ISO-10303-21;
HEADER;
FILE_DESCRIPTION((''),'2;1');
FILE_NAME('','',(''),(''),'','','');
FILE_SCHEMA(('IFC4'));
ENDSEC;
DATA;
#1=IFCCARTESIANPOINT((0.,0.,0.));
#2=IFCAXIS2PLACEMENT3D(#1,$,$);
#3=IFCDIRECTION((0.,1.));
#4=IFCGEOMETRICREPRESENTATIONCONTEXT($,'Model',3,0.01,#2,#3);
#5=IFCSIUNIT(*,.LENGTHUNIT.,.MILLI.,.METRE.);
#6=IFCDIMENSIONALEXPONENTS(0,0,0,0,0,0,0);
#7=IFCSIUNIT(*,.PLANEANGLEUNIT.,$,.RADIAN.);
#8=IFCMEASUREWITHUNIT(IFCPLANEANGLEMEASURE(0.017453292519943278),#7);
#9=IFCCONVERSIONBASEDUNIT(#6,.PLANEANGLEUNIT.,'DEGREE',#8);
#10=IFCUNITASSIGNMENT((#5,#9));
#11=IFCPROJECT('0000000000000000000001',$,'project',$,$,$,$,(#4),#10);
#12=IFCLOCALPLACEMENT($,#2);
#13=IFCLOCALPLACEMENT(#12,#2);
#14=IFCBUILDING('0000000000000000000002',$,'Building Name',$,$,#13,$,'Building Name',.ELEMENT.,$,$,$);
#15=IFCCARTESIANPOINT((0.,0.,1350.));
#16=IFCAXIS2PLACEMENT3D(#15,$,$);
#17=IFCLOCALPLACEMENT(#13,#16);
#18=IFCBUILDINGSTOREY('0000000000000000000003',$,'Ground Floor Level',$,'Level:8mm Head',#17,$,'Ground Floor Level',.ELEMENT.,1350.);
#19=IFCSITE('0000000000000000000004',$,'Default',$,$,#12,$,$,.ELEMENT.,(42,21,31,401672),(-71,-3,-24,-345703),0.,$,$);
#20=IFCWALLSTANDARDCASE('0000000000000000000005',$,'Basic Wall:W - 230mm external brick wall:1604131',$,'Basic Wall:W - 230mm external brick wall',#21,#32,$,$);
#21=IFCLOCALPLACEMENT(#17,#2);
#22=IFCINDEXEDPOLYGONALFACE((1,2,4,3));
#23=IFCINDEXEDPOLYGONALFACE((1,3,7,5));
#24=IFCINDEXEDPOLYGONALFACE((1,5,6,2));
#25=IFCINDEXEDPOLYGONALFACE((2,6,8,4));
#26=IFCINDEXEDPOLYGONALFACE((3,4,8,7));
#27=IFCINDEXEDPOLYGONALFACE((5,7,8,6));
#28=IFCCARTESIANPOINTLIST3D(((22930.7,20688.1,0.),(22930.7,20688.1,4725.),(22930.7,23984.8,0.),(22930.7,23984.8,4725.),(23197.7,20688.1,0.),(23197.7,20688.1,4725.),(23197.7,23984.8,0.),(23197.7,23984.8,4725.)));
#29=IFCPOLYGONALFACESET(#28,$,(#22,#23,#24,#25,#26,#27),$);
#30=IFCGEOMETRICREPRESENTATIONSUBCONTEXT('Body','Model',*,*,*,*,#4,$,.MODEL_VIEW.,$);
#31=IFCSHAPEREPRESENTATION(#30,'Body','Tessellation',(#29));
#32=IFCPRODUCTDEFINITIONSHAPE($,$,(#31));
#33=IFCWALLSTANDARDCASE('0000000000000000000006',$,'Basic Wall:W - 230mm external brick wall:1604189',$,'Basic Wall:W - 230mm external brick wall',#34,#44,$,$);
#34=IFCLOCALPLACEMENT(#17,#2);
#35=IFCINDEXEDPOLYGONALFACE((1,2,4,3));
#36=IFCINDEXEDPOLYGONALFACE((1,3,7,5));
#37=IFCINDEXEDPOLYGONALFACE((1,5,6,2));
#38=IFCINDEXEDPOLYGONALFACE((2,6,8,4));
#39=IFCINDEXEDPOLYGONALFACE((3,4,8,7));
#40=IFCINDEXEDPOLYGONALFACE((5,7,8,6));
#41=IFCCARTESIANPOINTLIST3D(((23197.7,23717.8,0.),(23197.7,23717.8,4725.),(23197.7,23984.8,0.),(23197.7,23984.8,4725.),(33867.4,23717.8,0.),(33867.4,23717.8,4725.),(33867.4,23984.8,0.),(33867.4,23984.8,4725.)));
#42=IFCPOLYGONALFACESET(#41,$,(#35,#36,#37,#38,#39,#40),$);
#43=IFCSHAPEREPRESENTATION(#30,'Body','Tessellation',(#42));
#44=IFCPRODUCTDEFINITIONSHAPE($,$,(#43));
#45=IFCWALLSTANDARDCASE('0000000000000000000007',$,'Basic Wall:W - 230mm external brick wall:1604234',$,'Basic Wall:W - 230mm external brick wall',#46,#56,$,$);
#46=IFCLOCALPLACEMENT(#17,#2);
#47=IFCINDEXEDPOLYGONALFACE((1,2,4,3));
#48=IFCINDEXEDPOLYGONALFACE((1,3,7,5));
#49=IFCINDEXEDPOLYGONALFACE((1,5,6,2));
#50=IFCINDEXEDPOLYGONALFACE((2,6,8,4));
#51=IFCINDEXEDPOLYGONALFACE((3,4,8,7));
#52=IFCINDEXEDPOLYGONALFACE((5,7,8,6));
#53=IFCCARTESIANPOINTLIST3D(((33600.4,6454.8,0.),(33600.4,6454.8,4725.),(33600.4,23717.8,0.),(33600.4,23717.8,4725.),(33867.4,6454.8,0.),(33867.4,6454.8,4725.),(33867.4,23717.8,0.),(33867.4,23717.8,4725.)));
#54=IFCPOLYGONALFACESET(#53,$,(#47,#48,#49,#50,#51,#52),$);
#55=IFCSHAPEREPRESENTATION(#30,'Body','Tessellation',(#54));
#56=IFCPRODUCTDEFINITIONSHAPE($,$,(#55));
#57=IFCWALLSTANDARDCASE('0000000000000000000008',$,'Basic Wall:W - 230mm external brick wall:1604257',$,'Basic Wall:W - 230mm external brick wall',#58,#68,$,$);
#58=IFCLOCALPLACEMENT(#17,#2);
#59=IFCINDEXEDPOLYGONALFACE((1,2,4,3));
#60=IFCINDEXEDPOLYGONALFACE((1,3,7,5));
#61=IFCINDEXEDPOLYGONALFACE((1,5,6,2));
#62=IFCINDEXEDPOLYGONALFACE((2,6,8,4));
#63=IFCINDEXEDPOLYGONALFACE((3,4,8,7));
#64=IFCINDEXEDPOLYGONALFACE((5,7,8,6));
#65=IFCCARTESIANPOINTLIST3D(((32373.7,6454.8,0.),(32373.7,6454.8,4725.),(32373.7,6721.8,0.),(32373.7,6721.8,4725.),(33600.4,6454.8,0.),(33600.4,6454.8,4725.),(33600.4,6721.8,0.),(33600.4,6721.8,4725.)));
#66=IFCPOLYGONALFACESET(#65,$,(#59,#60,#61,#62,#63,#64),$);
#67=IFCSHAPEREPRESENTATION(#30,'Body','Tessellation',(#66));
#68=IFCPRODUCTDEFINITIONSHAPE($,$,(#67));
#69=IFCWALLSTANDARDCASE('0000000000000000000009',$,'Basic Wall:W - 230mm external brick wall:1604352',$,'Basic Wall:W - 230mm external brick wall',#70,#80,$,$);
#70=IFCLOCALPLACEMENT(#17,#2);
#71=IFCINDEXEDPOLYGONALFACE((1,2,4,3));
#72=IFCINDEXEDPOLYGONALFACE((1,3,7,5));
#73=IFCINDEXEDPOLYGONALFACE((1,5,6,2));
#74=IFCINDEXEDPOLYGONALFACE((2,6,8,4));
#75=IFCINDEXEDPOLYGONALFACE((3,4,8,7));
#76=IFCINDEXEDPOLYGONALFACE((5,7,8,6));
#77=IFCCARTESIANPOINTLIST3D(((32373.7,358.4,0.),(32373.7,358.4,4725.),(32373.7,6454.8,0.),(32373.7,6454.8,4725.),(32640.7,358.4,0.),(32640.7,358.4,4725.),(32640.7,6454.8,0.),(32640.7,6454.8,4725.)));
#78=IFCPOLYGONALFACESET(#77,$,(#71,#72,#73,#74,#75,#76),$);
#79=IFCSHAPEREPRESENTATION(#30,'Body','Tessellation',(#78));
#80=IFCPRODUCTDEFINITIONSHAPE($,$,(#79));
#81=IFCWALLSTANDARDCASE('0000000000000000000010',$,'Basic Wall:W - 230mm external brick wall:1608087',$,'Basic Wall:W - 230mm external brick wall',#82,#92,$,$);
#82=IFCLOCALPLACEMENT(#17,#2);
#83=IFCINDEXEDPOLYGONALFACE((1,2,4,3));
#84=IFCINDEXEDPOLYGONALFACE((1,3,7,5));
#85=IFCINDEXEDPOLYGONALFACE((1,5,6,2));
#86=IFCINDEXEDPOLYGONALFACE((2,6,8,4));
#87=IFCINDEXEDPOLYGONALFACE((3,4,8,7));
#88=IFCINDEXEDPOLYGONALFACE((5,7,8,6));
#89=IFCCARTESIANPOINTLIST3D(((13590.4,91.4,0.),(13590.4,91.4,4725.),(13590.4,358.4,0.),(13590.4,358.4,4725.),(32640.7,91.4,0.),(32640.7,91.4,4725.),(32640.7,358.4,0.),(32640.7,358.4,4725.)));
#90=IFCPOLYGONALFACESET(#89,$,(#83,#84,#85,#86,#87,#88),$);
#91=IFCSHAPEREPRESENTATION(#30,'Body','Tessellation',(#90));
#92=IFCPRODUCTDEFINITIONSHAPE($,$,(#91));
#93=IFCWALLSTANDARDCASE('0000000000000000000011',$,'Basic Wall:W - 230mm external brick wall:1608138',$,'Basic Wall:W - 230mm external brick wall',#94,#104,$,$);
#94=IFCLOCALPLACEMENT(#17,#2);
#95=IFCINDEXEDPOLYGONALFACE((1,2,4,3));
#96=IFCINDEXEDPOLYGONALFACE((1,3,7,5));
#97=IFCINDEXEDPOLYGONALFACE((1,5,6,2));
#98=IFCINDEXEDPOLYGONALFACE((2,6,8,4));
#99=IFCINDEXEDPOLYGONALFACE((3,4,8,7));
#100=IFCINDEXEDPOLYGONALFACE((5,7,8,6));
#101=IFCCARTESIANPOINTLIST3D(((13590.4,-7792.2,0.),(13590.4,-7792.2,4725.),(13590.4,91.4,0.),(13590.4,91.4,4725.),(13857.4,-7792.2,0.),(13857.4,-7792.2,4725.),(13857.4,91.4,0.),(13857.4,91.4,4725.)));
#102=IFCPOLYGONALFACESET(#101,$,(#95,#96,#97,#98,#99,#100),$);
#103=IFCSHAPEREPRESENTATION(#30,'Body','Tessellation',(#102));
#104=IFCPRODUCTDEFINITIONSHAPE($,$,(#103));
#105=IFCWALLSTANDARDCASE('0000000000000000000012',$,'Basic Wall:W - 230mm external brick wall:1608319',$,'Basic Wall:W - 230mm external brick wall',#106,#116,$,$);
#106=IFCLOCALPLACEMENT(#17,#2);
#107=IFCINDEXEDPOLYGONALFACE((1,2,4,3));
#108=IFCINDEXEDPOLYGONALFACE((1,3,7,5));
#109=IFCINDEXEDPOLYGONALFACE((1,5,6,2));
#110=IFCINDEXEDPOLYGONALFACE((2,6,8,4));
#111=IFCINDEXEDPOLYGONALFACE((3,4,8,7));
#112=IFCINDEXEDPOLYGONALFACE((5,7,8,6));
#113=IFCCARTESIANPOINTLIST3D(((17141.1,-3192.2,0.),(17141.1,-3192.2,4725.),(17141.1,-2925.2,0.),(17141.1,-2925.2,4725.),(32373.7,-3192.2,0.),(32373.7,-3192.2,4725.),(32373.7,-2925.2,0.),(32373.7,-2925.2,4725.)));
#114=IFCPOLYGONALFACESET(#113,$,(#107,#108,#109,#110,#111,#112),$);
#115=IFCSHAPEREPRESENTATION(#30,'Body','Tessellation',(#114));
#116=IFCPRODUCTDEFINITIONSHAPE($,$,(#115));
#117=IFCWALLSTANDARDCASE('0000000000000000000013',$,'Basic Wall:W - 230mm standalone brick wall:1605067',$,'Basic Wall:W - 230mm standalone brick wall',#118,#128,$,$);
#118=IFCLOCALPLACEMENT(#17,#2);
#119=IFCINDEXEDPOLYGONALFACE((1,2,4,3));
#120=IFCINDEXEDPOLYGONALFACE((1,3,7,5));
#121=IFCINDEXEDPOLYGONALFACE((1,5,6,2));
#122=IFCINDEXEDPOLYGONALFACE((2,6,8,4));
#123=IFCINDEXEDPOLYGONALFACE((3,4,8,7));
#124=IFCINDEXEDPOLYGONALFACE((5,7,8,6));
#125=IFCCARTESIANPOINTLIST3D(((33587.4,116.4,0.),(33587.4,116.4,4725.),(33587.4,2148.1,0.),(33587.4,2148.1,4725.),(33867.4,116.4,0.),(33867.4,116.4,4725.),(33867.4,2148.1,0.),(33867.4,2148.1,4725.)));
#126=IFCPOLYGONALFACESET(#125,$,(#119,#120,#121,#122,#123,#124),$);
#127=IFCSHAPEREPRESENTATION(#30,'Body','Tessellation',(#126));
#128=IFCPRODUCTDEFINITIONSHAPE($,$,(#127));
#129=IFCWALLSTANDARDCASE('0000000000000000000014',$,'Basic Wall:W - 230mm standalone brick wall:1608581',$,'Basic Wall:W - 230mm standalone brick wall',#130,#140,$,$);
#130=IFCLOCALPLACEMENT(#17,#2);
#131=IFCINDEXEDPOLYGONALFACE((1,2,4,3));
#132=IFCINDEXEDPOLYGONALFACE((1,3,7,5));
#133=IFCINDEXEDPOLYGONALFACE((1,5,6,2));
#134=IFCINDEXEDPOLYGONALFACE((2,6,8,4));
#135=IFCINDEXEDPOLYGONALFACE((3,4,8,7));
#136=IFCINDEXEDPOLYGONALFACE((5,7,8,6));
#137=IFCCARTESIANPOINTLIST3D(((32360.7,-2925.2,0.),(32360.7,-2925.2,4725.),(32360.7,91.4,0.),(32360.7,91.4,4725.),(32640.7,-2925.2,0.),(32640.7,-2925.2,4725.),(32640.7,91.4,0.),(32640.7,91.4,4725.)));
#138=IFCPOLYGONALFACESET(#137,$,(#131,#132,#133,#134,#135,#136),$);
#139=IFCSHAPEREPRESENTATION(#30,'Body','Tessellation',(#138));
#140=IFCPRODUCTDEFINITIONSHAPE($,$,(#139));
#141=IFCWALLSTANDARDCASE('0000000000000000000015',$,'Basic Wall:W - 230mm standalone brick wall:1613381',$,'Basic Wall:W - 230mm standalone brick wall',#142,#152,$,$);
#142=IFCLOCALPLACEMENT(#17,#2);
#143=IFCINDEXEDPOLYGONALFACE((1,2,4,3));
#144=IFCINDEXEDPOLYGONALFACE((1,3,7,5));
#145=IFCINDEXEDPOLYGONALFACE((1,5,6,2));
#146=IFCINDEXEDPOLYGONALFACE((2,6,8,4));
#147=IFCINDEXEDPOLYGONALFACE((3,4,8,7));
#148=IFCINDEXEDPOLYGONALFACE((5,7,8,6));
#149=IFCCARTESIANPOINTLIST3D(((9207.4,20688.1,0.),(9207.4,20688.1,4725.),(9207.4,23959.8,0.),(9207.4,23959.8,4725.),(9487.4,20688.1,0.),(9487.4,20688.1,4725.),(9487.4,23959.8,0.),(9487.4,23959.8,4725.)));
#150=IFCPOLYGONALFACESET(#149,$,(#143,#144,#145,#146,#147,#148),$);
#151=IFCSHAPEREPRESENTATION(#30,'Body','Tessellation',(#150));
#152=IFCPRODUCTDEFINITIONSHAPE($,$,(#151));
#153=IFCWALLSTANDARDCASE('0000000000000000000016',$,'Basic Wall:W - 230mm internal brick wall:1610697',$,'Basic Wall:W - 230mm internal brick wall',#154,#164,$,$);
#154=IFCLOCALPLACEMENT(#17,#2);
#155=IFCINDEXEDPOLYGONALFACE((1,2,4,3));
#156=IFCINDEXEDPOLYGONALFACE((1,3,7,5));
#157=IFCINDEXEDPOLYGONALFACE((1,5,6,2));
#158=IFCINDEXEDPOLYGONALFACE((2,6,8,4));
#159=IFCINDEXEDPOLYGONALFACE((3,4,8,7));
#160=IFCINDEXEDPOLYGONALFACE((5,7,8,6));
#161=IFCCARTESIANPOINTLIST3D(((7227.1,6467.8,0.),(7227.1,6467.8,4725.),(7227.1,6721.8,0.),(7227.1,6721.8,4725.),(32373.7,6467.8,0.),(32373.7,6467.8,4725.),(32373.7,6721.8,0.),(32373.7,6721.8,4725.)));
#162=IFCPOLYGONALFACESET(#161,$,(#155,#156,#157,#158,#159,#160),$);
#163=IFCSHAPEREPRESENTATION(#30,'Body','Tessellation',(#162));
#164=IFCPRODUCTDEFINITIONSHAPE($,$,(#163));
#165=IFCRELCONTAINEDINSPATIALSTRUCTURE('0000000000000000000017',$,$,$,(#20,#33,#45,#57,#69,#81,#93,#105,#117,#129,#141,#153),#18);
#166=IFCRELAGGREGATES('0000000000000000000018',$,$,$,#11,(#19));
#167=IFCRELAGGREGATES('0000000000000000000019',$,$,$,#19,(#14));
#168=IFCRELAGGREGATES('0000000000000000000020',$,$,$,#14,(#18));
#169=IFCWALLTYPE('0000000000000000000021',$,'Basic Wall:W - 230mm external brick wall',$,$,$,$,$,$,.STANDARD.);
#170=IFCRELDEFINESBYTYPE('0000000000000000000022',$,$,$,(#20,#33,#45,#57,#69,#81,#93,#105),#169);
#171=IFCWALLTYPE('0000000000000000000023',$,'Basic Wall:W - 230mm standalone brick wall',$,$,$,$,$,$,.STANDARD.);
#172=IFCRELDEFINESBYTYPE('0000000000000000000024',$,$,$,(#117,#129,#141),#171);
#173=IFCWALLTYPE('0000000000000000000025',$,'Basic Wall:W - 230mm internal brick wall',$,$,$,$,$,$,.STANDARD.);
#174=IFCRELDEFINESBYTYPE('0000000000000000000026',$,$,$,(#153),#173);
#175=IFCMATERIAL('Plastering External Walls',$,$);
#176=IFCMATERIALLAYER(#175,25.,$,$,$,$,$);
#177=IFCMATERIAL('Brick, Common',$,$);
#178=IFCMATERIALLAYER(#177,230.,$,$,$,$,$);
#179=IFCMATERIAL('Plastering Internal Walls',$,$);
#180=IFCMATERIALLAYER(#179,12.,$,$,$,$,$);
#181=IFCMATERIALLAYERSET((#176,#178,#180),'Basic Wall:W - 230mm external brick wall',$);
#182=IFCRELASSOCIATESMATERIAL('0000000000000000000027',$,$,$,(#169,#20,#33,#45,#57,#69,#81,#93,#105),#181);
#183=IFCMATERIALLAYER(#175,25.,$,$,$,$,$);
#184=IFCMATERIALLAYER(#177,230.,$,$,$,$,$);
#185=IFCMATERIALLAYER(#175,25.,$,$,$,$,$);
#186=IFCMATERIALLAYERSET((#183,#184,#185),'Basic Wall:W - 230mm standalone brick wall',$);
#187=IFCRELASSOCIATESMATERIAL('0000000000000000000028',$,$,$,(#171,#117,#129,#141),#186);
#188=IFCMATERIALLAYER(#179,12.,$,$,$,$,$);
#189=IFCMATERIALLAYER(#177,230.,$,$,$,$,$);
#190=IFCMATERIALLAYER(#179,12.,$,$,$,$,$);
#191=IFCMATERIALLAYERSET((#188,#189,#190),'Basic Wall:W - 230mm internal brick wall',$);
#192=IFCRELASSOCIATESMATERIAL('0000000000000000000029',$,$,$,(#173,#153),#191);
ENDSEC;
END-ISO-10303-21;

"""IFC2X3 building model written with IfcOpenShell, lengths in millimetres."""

from ifc_helpers import new_model, entity, si_unit, converted_unit, direction, frame, frame_2d, origin, place, context, subcontext, project, spatial, rectangle, extrude, material, layer, layer_set, layer_usage, type_object, element, save


model = new_model("IFC2X3")

# Units and contexts
model_context = context("Model", 3, precision=0.01, world=origin(), true_north=direction((0.0, 1.0)))
body_context = subcontext(model_context, "Body", "Model", "MODEL_VIEW")
ifc_project = project(units=[si_unit("LENGTHUNIT", "METRE", prefix="MILLI"), converted_unit("PLANEANGLEUNIT", "DEGREE", entity("IfcPlaneAngleMeasure", 0.017453292519943278), si_unit("PLANEANGLEUNIT", "RADIAN"), dimensions=[0, 0, 0, 0, 0, 0, 0])], contexts=[model_context])

# Site, building, storey
site_placement = place(None, origin())
site = spatial("IfcSite", under=ifc_project, at=site_placement, Name="Default", CompositionType="ELEMENT", RefLatitude=(42, 21, 31, 401672), RefLongitude=(-71, -3, -24, -345703), RefElevation=0.0)
building_placement = place(site_placement, origin())
building = spatial("IfcBuilding", under=site, at=building_placement, Name="Building Name", LongName="Building Name", CompositionType="ELEMENT")
storey_placement = place(building_placement, frame((0.0, 0.0, 1350.0)))
storey = spatial("IfcBuildingStorey", under=building, at=storey_placement, Name="Ground Floor Level", ObjectType="Level:8mm Head", LongName="Ground Floor Level", CompositionType="ELEMENT", Elevation=1350.0)

# Walls
ifc_material_1 = material(Name="Plastering External Walls")
ifc_layer_1 = layer(ifc_material_1, 25.0)
ifc_material_2 = material(Name="Brick, Common")
ifc_layer_2 = layer(ifc_material_2, 230.0)
ifc_material_3 = material(Name="Plastering Internal Walls")
ifc_layer_3 = layer(ifc_material_3, 12.0)
ifc_layer_set_1 = layer_set([ifc_layer_1, ifc_layer_2, ifc_layer_3], Name="Basic Wall:W - 230mm external brick wall")
ifc_layer_usage_1 = layer_usage(ifc_layer_set_1, "AXIS2", "NEGATIVE", 133.5)
wall_type_1 = type_object("IfcWallType", Name="Basic Wall:W - 230mm external brick wall", PredefinedType="STANDARD", material=ifc_layer_set_1)
wall_1_placement = place(storey_placement, frame((23064.2, 20688.1, 0.0), z_axis=(0.0, 0.0, 1.0), x_axis=(0.0, 1.0, 0.0)))
element("IfcWallStandardCase", 1, at=wall_1_placement, inside=storey, type_object=wall_type_1, material=ifc_layer_usage_1, Name="Basic Wall:W - 230mm external brick wall:1604131", ObjectType="Basic Wall:W - 230mm external brick wall", context=body_context, shape_type="SweptSolid", body=[
    extrude(rectangle(XDim=3296.7, YDim=267.0, at=frame_2d((1648.3, 0.0), x_axis=(-1.0, 0.0))), origin(), (0.0, 0.0, 1.0), 4725.0),
])
ifc_layer_usage_2 = layer_usage(ifc_layer_set_1, "AXIS2", "NEGATIVE", 133.5)
wall_2_placement = place(storey_placement, frame((23197.7, 23851.3, 0.0)))
element("IfcWallStandardCase", 2, at=wall_2_placement, inside=storey, type_object=wall_type_1, material=ifc_layer_usage_2, Name="Basic Wall:W - 230mm external brick wall:1604189", ObjectType="Basic Wall:W - 230mm external brick wall", context=body_context, shape_type="SweptSolid", body=[
    extrude(rectangle(XDim=10669.7, YDim=267.0, at=frame_2d((5334.8, 0.0), x_axis=(-1.0, 0.0))), origin(), (0.0, 0.0, 1.0), 4725.0),
])
ifc_layer_usage_3 = layer_usage(ifc_layer_set_1, "AXIS2", "NEGATIVE", 133.5)
wall_3_placement = place(storey_placement, frame((33733.9, 23717.8, 0.0), z_axis=(0.0, 0.0, 1.0), x_axis=(0.0, -1.0, 0.0)))
element("IfcWallStandardCase", 3, at=wall_3_placement, inside=storey, type_object=wall_type_1, material=ifc_layer_usage_3, Name="Basic Wall:W - 230mm external brick wall:1604234", ObjectType="Basic Wall:W - 230mm external brick wall", context=body_context, shape_type="SweptSolid", body=[
    extrude(rectangle(XDim=17263.0, YDim=267.0, at=frame_2d((8631.5, 0.0), x_axis=(-1.0, 0.0))), origin(), (0.0, 0.0, 1.0), 4725.0),
])
ifc_layer_usage_4 = layer_usage(ifc_layer_set_1, "AXIS2", "NEGATIVE", 133.5)
wall_4_placement = place(storey_placement, frame((33600.4, 6588.3, 0.0), z_axis=(0.0, 0.0, 1.0), x_axis=(-1.0, 0.0, 0.0)))
element("IfcWallStandardCase", 4, at=wall_4_placement, inside=storey, type_object=wall_type_1, material=ifc_layer_usage_4, Name="Basic Wall:W - 230mm external brick wall:1604257", ObjectType="Basic Wall:W - 230mm external brick wall", context=body_context, shape_type="SweptSolid", body=[
    extrude(rectangle(XDim=1226.7, YDim=267.0, at=frame_2d((613.3, 0.0), x_axis=(-1.0, 0.0))), origin(), (0.0, 0.0, 1.0), 4725.0),
])
ifc_layer_usage_5 = layer_usage(ifc_layer_set_1, "AXIS2", "NEGATIVE", 133.5)
wall_5_placement = place(storey_placement, frame((32507.2, 6454.8, 0.0), z_axis=(0.0, 0.0, 1.0), x_axis=(0.0, -1.0, 0.0)))
element("IfcWallStandardCase", 5, at=wall_5_placement, inside=storey, type_object=wall_type_1, material=ifc_layer_usage_5, Name="Basic Wall:W - 230mm external brick wall:1604352", ObjectType="Basic Wall:W - 230mm external brick wall", context=body_context, shape_type="SweptSolid", body=[
    extrude(rectangle(XDim=6096.3, YDim=267.0, at=frame_2d((3048.2, 0.0), x_axis=(-1.0, 0.0))), origin(), (0.0, 0.0, 1.0), 4725.0),
])
ifc_layer_usage_6 = layer_usage(ifc_layer_set_1, "AXIS2", "NEGATIVE", 133.5)
wall_6_placement = place(storey_placement, frame((32640.7, 224.9, 0.0), z_axis=(0.0, 0.0, 1.0), x_axis=(-1.0, 0.0, 0.0)))
element("IfcWallStandardCase", 6, at=wall_6_placement, inside=storey, type_object=wall_type_1, material=ifc_layer_usage_6, Name="Basic Wall:W - 230mm external brick wall:1608087", ObjectType="Basic Wall:W - 230mm external brick wall", context=body_context, shape_type="SweptSolid", body=[
    extrude(rectangle(XDim=19050.3, YDim=267.0, at=frame_2d((9525.2, 0.0), x_axis=(-1.0, 0.0))), origin(), (0.0, 0.0, 1.0), 4725.0),
])
ifc_layer_usage_7 = layer_usage(ifc_layer_set_1, "AXIS2", "NEGATIVE", 133.5)
wall_7_placement = place(storey_placement, frame((13723.9, 91.4, 0.0), z_axis=(0.0, 0.0, 1.0), x_axis=(0.0, -1.0, 0.0)))
element("IfcWallStandardCase", 7, at=wall_7_placement, inside=storey, type_object=wall_type_1, material=ifc_layer_usage_7, Name="Basic Wall:W - 230mm external brick wall:1608138", ObjectType="Basic Wall:W - 230mm external brick wall", context=body_context, shape_type="SweptSolid", body=[
    extrude(rectangle(XDim=7883.7, YDim=267.0, at=frame_2d((3941.8, 0.0), x_axis=(-1.0, 0.0))), origin(), (0.0, 0.0, 1.0), 4725.0),
])
ifc_layer_usage_8 = layer_usage(ifc_layer_set_1, "AXIS2", "NEGATIVE", 133.5)
wall_8_placement = place(storey_placement, frame((17141.1, -3058.7, 0.0)))
element("IfcWallStandardCase", 8, at=wall_8_placement, inside=storey, type_object=wall_type_1, material=ifc_layer_usage_8, Name="Basic Wall:W - 230mm external brick wall:1608319", ObjectType="Basic Wall:W - 230mm external brick wall", context=body_context, shape_type="SweptSolid", body=[
    extrude(rectangle(XDim=15232.7, YDim=267.0, at=frame_2d((7616.3, 0.0), x_axis=(-1.0, 0.0))), origin(), (0.0, 0.0, 1.0), 4725.0),
])
ifc_layer_4 = layer(ifc_material_1, 25.0)
ifc_layer_5 = layer(ifc_material_2, 230.0)
ifc_layer_6 = layer(ifc_material_1, 25.0)
ifc_layer_set_2 = layer_set([ifc_layer_4, ifc_layer_5, ifc_layer_6], Name="Basic Wall:W - 230mm standalone brick wall")
ifc_layer_usage_9 = layer_usage(ifc_layer_set_2, "AXIS2", "NEGATIVE", 140.0)
wall_type_2 = type_object("IfcWallType", Name="Basic Wall:W - 230mm standalone brick wall", PredefinedType="STANDARD", material=ifc_layer_set_2)
wall_9_placement = place(storey_placement, frame((33727.4, 116.4, 0.0), z_axis=(0.0, 0.0, 1.0), x_axis=(0.0, 1.0, 0.0)))
element("IfcWallStandardCase", 9, at=wall_9_placement, inside=storey, type_object=wall_type_2, material=ifc_layer_usage_9, Name="Basic Wall:W - 230mm standalone brick wall:1605067", ObjectType="Basic Wall:W - 230mm standalone brick wall", context=body_context, shape_type="SweptSolid", body=[
    extrude(rectangle(XDim=2031.7, YDim=280.0, at=frame_2d((1015.8, 0.0), x_axis=(-1.0, 0.0))), origin(), (0.0, 0.0, 1.0), 4725.0),
])
ifc_layer_usage_10 = layer_usage(ifc_layer_set_2, "AXIS2", "NEGATIVE", 140.0)
wall_10_placement = place(storey_placement, frame((32500.7, 91.4, 0.0), z_axis=(0.0, 0.0, 1.0), x_axis=(0.0, -1.0, 0.0)))
element("IfcWallStandardCase", 10, at=wall_10_placement, inside=storey, type_object=wall_type_2, material=ifc_layer_usage_10, Name="Basic Wall:W - 230mm standalone brick wall:1608581", ObjectType="Basic Wall:W - 230mm standalone brick wall", context=body_context, shape_type="SweptSolid", body=[
    extrude(rectangle(XDim=3016.7, YDim=280.0, at=frame_2d((1508.3, 0.0), x_axis=(-1.0, 0.0))), origin(), (0.0, 0.0, 1.0), 4725.0),
])
ifc_layer_usage_11 = layer_usage(ifc_layer_set_2, "AXIS2", "NEGATIVE", 140.0)
wall_11_placement = place(storey_placement, frame((9347.4, 20688.1, 0.0), z_axis=(0.0, 0.0, 1.0), x_axis=(0.0, 1.0, 0.0)))
element("IfcWallStandardCase", 11, at=wall_11_placement, inside=storey, type_object=wall_type_2, material=ifc_layer_usage_11, Name="Basic Wall:W - 230mm standalone brick wall:1613381", ObjectType="Basic Wall:W - 230mm standalone brick wall", context=body_context, shape_type="SweptSolid", body=[
    extrude(rectangle(XDim=3271.7, YDim=280.0, at=frame_2d((1635.8, 0.0), x_axis=(-1.0, 0.0))), origin(), (0.0, 0.0, 1.0), 4725.0),
])
ifc_layer_7 = layer(ifc_material_3, 12.0)
ifc_layer_8 = layer(ifc_material_2, 230.0)
ifc_layer_9 = layer(ifc_material_3, 12.0)
ifc_layer_set_3 = layer_set([ifc_layer_7, ifc_layer_8, ifc_layer_9], Name="Basic Wall:W - 230mm internal brick wall")
ifc_layer_usage_12 = layer_usage(ifc_layer_set_3, "AXIS2", "NEGATIVE", 127.0)
wall_type_3 = type_object("IfcWallType", Name="Basic Wall:W - 230mm internal brick wall", PredefinedType="STANDARD", material=ifc_layer_set_3)
wall_12_placement = place(storey_placement, frame((32373.7, 6594.8, 0.0), z_axis=(0.0, 0.0, 1.0), x_axis=(-1.0, 0.0, 0.0)))
element("IfcWallStandardCase", 12, at=wall_12_placement, inside=storey, type_object=wall_type_3, material=ifc_layer_usage_12, Name="Basic Wall:W - 230mm internal brick wall:1610697", ObjectType="Basic Wall:W - 230mm internal brick wall", context=body_context, shape_type="SweptSolid", body=[
    extrude(rectangle(XDim=25146.7, YDim=254.0, at=frame_2d((12573.3, 0.0), x_axis=(-1.0, 0.0))), origin(), (0.0, 0.0, 1.0), 4725.0),
])

save(model, "model.ifc")
